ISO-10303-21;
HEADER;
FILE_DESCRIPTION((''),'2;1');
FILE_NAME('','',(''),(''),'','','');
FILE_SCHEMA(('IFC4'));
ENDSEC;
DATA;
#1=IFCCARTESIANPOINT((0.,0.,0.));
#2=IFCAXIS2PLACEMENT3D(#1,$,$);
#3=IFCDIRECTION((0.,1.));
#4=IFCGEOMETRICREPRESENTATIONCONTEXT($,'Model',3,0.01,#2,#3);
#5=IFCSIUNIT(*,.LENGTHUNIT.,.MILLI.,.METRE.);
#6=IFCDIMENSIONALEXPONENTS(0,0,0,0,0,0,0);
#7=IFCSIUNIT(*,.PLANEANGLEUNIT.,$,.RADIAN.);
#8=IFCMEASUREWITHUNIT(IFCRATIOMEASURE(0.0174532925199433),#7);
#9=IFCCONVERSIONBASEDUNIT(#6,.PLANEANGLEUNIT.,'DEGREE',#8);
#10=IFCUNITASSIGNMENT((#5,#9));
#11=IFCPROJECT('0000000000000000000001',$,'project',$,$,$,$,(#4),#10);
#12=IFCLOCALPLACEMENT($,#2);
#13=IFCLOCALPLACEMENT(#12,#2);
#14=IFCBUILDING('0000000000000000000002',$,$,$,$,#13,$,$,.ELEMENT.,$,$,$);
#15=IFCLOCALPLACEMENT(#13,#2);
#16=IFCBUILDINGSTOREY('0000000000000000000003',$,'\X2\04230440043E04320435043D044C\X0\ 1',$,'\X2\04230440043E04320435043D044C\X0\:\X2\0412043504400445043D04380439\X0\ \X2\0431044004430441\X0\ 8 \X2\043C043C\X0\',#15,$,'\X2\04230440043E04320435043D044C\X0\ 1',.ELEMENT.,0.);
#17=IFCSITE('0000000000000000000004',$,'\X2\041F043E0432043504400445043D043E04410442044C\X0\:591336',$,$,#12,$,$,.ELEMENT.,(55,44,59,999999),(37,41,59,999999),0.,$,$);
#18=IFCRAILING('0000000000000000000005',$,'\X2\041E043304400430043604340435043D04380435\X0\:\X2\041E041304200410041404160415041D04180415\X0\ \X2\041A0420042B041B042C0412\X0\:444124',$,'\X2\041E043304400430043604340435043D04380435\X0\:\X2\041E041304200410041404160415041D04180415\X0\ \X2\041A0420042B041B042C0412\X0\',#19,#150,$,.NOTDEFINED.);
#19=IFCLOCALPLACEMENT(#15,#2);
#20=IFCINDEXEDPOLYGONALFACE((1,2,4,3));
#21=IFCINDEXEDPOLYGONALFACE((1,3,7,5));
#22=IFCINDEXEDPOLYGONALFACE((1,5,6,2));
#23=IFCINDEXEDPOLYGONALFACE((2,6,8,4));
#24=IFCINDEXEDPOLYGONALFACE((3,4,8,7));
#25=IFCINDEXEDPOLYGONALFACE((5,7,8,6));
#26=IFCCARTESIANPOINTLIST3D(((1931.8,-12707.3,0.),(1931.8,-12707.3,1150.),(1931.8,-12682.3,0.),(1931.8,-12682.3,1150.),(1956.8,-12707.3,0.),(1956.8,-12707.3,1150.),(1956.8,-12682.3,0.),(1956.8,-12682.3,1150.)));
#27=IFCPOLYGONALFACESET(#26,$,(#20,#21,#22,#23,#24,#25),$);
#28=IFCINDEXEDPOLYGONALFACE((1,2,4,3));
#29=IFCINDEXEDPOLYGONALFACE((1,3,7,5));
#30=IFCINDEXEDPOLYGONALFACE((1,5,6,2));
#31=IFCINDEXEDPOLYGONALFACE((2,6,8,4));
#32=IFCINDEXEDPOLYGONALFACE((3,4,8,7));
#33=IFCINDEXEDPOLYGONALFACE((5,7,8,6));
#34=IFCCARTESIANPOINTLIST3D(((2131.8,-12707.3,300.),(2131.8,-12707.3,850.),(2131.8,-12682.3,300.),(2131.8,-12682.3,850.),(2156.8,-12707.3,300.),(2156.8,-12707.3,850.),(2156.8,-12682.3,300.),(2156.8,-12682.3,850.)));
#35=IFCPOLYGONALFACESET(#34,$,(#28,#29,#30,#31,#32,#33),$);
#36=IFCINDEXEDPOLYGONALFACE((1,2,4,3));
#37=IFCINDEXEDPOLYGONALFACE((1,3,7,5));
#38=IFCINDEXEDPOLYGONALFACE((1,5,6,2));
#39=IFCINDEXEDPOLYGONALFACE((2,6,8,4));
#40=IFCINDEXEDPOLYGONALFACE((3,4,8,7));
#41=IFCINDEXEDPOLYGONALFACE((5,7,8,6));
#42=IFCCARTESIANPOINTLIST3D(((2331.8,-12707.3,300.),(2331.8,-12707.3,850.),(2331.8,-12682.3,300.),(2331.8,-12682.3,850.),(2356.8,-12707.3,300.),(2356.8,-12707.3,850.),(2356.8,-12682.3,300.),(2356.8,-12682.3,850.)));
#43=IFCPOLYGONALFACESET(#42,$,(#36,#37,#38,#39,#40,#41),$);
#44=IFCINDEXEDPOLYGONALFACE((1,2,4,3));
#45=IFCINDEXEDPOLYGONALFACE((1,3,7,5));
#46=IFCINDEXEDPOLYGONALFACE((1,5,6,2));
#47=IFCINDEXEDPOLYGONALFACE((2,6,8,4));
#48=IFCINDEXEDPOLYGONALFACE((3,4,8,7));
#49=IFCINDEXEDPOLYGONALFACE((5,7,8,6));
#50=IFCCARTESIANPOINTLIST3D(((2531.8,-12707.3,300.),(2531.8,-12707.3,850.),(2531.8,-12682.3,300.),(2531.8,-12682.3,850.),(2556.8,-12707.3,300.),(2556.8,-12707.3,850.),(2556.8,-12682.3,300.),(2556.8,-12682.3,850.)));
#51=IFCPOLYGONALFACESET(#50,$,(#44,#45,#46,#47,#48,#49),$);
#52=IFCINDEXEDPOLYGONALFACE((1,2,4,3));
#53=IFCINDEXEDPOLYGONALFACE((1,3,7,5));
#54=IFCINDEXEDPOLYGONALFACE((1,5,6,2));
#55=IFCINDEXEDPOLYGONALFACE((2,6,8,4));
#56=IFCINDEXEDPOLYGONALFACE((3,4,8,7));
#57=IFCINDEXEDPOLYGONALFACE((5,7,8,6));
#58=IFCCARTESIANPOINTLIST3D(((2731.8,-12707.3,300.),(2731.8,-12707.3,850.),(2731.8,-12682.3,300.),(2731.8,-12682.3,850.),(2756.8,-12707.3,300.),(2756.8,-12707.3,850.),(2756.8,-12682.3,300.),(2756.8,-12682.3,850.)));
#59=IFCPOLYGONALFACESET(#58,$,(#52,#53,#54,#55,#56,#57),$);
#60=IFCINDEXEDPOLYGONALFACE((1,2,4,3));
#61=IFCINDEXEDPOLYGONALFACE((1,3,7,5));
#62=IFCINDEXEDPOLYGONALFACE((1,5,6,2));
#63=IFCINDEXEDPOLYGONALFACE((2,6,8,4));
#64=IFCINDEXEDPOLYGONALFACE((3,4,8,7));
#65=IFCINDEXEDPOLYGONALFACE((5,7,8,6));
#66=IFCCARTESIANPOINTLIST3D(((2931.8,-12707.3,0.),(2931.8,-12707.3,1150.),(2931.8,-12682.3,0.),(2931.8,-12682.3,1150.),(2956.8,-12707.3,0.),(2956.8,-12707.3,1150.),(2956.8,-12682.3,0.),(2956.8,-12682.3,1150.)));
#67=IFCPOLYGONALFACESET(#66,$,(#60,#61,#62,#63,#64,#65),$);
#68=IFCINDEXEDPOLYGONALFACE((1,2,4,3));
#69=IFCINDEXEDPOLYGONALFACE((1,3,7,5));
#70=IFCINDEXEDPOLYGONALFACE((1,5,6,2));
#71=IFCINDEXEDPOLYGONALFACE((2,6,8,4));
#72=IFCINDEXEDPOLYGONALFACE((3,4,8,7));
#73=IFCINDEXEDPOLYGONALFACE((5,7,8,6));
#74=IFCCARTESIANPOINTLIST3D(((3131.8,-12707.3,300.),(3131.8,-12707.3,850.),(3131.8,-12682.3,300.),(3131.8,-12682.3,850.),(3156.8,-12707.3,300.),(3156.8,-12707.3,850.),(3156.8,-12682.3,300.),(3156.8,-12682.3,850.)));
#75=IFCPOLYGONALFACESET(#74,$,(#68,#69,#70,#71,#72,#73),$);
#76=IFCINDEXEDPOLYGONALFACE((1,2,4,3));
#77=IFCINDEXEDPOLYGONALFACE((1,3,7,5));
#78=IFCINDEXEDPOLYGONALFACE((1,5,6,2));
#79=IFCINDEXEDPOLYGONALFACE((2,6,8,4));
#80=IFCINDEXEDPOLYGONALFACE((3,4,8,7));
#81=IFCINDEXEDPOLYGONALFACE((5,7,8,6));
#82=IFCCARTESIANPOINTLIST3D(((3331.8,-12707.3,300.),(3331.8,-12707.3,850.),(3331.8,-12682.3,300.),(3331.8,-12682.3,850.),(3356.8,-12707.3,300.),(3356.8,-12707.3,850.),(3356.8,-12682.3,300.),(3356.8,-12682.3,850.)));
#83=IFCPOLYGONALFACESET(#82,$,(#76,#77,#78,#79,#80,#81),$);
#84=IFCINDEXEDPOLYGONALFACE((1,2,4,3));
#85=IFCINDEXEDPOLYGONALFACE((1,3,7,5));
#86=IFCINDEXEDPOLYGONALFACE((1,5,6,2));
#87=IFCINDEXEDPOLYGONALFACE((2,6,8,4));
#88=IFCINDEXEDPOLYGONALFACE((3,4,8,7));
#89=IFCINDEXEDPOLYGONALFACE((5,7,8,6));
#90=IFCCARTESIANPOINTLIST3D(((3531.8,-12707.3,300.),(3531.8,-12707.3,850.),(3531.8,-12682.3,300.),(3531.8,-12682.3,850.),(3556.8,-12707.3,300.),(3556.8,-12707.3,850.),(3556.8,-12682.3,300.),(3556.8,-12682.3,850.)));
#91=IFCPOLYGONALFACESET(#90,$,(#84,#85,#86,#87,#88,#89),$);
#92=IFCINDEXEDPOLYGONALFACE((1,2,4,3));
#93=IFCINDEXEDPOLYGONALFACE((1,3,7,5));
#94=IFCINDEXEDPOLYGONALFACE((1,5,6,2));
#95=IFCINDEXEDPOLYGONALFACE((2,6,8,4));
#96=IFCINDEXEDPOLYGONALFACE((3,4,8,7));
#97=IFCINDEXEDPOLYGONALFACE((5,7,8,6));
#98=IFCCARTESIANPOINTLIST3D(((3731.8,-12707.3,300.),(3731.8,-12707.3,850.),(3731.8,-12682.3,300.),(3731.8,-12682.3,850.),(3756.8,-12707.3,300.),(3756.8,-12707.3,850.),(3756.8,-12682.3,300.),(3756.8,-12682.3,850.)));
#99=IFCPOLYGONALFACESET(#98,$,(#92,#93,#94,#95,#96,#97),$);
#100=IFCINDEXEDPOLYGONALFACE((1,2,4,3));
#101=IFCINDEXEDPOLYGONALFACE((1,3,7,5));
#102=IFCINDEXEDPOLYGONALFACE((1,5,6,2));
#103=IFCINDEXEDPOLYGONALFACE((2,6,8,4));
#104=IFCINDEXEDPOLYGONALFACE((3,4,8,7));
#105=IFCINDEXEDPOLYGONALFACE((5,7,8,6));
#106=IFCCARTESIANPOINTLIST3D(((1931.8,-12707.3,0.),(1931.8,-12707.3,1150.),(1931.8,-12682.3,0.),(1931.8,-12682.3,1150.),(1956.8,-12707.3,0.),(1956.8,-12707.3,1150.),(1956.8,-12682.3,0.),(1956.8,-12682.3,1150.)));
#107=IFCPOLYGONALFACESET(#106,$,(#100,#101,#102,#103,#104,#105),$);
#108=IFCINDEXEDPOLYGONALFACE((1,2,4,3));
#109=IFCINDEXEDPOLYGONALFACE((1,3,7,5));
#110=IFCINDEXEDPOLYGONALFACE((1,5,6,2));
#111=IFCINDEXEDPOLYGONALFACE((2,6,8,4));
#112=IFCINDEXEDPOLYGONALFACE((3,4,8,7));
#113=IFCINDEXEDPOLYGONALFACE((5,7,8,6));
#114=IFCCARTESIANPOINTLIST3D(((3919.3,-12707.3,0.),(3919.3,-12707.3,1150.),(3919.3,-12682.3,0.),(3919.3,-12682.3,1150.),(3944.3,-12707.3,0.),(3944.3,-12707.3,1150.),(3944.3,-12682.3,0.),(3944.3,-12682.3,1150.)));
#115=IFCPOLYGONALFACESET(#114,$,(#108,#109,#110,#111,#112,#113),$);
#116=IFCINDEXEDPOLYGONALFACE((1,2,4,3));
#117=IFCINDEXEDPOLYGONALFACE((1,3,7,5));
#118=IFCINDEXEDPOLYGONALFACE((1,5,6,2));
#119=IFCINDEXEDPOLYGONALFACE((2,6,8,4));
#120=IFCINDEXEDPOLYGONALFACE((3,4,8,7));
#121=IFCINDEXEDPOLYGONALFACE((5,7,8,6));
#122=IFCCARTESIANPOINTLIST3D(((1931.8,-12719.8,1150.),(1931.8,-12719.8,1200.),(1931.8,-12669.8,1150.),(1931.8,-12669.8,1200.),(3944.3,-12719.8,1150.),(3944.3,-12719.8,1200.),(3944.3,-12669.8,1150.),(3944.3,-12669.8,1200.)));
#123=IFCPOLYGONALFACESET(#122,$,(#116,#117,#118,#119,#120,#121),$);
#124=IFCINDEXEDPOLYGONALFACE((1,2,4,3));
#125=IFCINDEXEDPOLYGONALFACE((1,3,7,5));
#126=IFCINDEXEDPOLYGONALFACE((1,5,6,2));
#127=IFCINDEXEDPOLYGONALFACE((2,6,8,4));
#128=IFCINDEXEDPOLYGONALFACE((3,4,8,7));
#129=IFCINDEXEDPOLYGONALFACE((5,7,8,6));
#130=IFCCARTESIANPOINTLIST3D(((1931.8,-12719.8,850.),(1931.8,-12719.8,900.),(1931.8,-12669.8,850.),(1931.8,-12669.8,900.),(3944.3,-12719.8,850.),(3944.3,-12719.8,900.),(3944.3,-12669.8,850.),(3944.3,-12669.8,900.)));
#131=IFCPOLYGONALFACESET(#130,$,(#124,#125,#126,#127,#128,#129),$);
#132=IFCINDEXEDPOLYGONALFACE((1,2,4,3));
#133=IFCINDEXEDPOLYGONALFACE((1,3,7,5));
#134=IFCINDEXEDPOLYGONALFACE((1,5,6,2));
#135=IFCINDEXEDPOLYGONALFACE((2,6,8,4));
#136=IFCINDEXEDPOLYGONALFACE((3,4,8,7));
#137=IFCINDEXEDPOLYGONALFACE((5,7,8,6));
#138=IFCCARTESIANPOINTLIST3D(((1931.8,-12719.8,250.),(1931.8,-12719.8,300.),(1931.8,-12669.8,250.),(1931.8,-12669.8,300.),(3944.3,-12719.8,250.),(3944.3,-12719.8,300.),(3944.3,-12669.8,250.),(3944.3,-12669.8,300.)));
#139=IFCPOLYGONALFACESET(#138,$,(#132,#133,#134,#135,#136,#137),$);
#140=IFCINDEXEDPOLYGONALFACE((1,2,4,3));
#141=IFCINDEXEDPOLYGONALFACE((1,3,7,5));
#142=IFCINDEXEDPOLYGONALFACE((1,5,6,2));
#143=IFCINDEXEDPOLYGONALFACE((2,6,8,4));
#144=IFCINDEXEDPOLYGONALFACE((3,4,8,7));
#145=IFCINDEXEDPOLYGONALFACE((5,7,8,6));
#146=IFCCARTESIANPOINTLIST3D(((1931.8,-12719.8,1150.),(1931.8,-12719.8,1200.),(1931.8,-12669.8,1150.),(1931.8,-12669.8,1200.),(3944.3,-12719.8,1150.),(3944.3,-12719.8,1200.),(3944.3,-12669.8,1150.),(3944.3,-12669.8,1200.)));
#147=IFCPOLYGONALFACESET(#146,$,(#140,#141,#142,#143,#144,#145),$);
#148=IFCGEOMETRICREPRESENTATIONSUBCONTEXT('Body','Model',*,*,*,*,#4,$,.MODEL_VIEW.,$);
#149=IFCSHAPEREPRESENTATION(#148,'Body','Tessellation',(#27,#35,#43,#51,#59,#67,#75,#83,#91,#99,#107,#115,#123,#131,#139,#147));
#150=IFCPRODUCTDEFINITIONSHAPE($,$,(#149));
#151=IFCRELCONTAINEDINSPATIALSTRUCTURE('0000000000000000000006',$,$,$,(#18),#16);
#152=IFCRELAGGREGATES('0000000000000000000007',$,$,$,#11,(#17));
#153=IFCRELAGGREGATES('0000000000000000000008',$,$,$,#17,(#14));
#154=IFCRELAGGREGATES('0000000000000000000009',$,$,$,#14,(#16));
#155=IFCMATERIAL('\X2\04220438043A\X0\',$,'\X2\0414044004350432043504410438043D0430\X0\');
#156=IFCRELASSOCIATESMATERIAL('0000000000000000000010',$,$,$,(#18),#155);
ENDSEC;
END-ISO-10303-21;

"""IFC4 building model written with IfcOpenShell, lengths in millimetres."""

from ifc_helpers import new_model, entity, si_unit, converted_unit, direction, frame, origin, place, context, subcontext, project, spatial, indexed_curve, outline, extrude, material, element, save


model = new_model("IFC4")

# Units and contexts
model_context = context("Model", 3, precision=0.01, world=origin(), true_north=direction((0.0, 1.0)))
body_context = subcontext(model_context, "Body", "Model", "MODEL_VIEW")
ifc_project = project(units=[si_unit("LENGTHUNIT", "METRE", prefix="MILLI"), converted_unit("PLANEANGLEUNIT", "DEGREE", entity("IfcRatioMeasure", 0.0174532925199433), si_unit("PLANEANGLEUNIT", "RADIAN"), dimensions=[0, 0, 0, 0, 0, 0, 0])], contexts=[model_context])

# Site, building, storey
site_placement = place(None, origin())
site = spatial("IfcSite", under=ifc_project, at=site_placement, Name="Поверхность:591336", CompositionType="ELEMENT", RefLatitude=(55, 44, 59, 999999), RefLongitude=(37, 41, 59, 999999), RefElevation=0.0)
building_placement = place(site_placement, origin())
building = spatial("IfcBuilding", under=site, at=building_placement, CompositionType="ELEMENT")
storey_placement = place(building_placement, origin())
storey = spatial("IfcBuildingStorey", under=building, at=storey_placement, Name="Уровень 1", ObjectType="Уровень:Верхний брус 8 мм", LongName="Уровень 1", CompositionType="ELEMENT", Elevation=0.0)

# Railing
ifc_material_1 = material(Name="Тик", Category="Древесина")
railing_1_placement = place(storey_placement, origin())
element("IfcRailing", 1, at=railing_1_placement, inside=storey, material=ifc_material_1, Name="Ограждение:ОГРАДЖЕНИЕ КРЫЛЬВ:444124", ObjectType="Ограждение:ОГРАДЖЕНИЕ КРЫЛЬВ", PredefinedType="NOTDEFINED", context=body_context, shape_type="SweptSolid", body=[
    extrude(outline(indexed_curve([(-12.5, -12.5), (12.5, -12.5), (12.5, 12.5), (-12.5, 12.5), (-12.5, -12.5)], self_intersect=False)), frame((1944.3, -12694.8, 0.0), z_axis=(0.0, 0.0, 1.0), x_axis=(0.0, 1.0, 0.0)), (0.0, 0.0, 1.0), 1150.0),
    extrude(outline(indexed_curve([(-12.5, -12.5), (12.5, -12.5), (12.5, 12.5), (-12.5, 12.5), (-12.5, -12.5)], self_intersect=False)), frame((2144.3, -12694.8, 300.0), z_axis=(0.0, 0.0, 1.0), x_axis=(0.0, 1.0, 0.0)), (0.0, 0.0, 1.0), 550.0),
    extrude(outline(indexed_curve([(-12.5, -12.5), (12.5, -12.5), (12.5, 12.5), (-12.5, 12.5), (-12.5, -12.5)], self_intersect=False)), frame((2344.3, -12694.8, 300.0), z_axis=(0.0, 0.0, 1.0), x_axis=(0.0, 1.0, 0.0)), (0.0, 0.0, 1.0), 550.0),
    extrude(outline(indexed_curve([(-12.5, -12.5), (12.5, -12.5), (12.5, 12.5), (-12.5, 12.5), (-12.5, -12.5)], self_intersect=False)), frame((2544.3, -12694.8, 300.0), z_axis=(0.0, 0.0, 1.0), x_axis=(0.0, 1.0, 0.0)), (0.0, 0.0, 1.0), 550.0),
    extrude(outline(indexed_curve([(-12.5, -12.5), (12.5, -12.5), (12.5, 12.5), (-12.5, 12.5), (-12.5, -12.5)], self_intersect=False)), frame((2744.3, -12694.8, 300.0), z_axis=(0.0, 0.0, 1.0), x_axis=(0.0, 1.0, 0.0)), (0.0, 0.0, 1.0), 550.0),
    extrude(outline(indexed_curve([(-12.5, -12.5), (12.5, -12.5), (12.5, 12.5), (-12.5, 12.5), (-12.5, -12.5)], self_intersect=False)), frame((2944.3, -12694.8, 0.0), z_axis=(0.0, 0.0, 1.0), x_axis=(0.0, 1.0, 0.0)), (0.0, 0.0, 1.0), 1150.0),
    extrude(outline(indexed_curve([(-12.5, -12.5), (12.5, -12.5), (12.5, 12.5), (-12.5, 12.5), (-12.5, -12.5)], self_intersect=False)), frame((3144.3, -12694.8, 300.0), z_axis=(0.0, 0.0, 1.0), x_axis=(0.0, 1.0, 0.0)), (0.0, 0.0, 1.0), 550.0),
    extrude(outline(indexed_curve([(-12.5, -12.5), (12.5, -12.5), (12.5, 12.5), (-12.5, 12.5), (-12.5, -12.5)], self_intersect=False)), frame((3344.3, -12694.8, 300.0), z_axis=(0.0, 0.0, 1.0), x_axis=(0.0, 1.0, 0.0)), (0.0, 0.0, 1.0), 550.0),
    extrude(outline(indexed_curve([(-12.5, -12.5), (12.5, -12.5), (12.5, 12.5), (-12.5, 12.5), (-12.5, -12.5)], self_intersect=False)), frame((3544.3, -12694.8, 300.0), z_axis=(0.0, 0.0, 1.0), x_axis=(0.0, 1.0, 0.0)), (0.0, 0.0, 1.0), 550.0),
    extrude(outline(indexed_curve([(-12.5, -12.5), (12.5, -12.5), (12.5, 12.5), (-12.5, 12.5), (-12.5, -12.5)], self_intersect=False)), frame((3744.3, -12694.8, 300.0), z_axis=(0.0, 0.0, 1.0), x_axis=(0.0, 1.0, 0.0)), (0.0, 0.0, 1.0), 550.0),
    extrude(outline(indexed_curve([(-12.5, -12.5), (12.5, -12.5), (12.5, 12.5), (-12.5, 12.5), (-12.5, -12.5)], self_intersect=False)), frame((1944.3, -12694.8, 0.0), z_axis=(0.0, 0.0, 1.0), x_axis=(0.0, 1.0, 0.0)), (0.0, 0.0, 1.0), 1150.0),
    extrude(outline(indexed_curve([(-12.5, -12.5), (12.5, -12.5), (12.5, 12.5), (-12.5, 12.5), (-12.5, -12.5)], self_intersect=False)), frame((3931.8, -12694.8, 0.0), z_axis=(0.0, 0.0, 1.0), x_axis=(0.0, 1.0, 0.0)), (0.0, 0.0, 1.0), 1150.0),
    extrude(outline(indexed_curve([(-1006.2, -25.0), (1006.2, -25.0), (1006.2, 25.0), (-1006.2, 25.0), (-1006.2, -25.0)], self_intersect=False)), frame((2938.1, -12694.8, 1150.0), z_axis=(0.0, 0.0, 1.0), x_axis=(-1.0, 0.0, 0.0)), (0.0, 0.0, 1.0), 50.0),
    extrude(outline(indexed_curve([(-1006.2, -25.0), (1006.2, -25.0), (1006.2, 25.0), (-1006.2, 25.0), (-1006.2, -25.0)], self_intersect=False)), frame((2938.1, -12694.8, 850.0), z_axis=(0.0, 0.0, 1.0), x_axis=(-1.0, 0.0, 0.0)), (0.0, 0.0, 1.0), 50.0),
    extrude(outline(indexed_curve([(-1006.2, -25.0), (1006.2, -25.0), (1006.2, 25.0), (-1006.2, 25.0), (-1006.2, -25.0)], self_intersect=False)), frame((2938.1, -12694.8, 250.0), z_axis=(0.0, 0.0, 1.0), x_axis=(-1.0, 0.0, 0.0)), (0.0, 0.0, 1.0), 50.0),
    extrude(outline(indexed_curve([(-1006.2, -25.0), (1006.2, -25.0), (1006.2, 25.0), (-1006.2, 25.0), (-1006.2, -25.0)], self_intersect=False)), frame((2938.1, -12694.8, 1150.0), z_axis=(0.0, 0.0, 1.0), x_axis=(-1.0, 0.0, 0.0)), (0.0, 0.0, 1.0), 50.0),
])

save(model, "model.ifc")
